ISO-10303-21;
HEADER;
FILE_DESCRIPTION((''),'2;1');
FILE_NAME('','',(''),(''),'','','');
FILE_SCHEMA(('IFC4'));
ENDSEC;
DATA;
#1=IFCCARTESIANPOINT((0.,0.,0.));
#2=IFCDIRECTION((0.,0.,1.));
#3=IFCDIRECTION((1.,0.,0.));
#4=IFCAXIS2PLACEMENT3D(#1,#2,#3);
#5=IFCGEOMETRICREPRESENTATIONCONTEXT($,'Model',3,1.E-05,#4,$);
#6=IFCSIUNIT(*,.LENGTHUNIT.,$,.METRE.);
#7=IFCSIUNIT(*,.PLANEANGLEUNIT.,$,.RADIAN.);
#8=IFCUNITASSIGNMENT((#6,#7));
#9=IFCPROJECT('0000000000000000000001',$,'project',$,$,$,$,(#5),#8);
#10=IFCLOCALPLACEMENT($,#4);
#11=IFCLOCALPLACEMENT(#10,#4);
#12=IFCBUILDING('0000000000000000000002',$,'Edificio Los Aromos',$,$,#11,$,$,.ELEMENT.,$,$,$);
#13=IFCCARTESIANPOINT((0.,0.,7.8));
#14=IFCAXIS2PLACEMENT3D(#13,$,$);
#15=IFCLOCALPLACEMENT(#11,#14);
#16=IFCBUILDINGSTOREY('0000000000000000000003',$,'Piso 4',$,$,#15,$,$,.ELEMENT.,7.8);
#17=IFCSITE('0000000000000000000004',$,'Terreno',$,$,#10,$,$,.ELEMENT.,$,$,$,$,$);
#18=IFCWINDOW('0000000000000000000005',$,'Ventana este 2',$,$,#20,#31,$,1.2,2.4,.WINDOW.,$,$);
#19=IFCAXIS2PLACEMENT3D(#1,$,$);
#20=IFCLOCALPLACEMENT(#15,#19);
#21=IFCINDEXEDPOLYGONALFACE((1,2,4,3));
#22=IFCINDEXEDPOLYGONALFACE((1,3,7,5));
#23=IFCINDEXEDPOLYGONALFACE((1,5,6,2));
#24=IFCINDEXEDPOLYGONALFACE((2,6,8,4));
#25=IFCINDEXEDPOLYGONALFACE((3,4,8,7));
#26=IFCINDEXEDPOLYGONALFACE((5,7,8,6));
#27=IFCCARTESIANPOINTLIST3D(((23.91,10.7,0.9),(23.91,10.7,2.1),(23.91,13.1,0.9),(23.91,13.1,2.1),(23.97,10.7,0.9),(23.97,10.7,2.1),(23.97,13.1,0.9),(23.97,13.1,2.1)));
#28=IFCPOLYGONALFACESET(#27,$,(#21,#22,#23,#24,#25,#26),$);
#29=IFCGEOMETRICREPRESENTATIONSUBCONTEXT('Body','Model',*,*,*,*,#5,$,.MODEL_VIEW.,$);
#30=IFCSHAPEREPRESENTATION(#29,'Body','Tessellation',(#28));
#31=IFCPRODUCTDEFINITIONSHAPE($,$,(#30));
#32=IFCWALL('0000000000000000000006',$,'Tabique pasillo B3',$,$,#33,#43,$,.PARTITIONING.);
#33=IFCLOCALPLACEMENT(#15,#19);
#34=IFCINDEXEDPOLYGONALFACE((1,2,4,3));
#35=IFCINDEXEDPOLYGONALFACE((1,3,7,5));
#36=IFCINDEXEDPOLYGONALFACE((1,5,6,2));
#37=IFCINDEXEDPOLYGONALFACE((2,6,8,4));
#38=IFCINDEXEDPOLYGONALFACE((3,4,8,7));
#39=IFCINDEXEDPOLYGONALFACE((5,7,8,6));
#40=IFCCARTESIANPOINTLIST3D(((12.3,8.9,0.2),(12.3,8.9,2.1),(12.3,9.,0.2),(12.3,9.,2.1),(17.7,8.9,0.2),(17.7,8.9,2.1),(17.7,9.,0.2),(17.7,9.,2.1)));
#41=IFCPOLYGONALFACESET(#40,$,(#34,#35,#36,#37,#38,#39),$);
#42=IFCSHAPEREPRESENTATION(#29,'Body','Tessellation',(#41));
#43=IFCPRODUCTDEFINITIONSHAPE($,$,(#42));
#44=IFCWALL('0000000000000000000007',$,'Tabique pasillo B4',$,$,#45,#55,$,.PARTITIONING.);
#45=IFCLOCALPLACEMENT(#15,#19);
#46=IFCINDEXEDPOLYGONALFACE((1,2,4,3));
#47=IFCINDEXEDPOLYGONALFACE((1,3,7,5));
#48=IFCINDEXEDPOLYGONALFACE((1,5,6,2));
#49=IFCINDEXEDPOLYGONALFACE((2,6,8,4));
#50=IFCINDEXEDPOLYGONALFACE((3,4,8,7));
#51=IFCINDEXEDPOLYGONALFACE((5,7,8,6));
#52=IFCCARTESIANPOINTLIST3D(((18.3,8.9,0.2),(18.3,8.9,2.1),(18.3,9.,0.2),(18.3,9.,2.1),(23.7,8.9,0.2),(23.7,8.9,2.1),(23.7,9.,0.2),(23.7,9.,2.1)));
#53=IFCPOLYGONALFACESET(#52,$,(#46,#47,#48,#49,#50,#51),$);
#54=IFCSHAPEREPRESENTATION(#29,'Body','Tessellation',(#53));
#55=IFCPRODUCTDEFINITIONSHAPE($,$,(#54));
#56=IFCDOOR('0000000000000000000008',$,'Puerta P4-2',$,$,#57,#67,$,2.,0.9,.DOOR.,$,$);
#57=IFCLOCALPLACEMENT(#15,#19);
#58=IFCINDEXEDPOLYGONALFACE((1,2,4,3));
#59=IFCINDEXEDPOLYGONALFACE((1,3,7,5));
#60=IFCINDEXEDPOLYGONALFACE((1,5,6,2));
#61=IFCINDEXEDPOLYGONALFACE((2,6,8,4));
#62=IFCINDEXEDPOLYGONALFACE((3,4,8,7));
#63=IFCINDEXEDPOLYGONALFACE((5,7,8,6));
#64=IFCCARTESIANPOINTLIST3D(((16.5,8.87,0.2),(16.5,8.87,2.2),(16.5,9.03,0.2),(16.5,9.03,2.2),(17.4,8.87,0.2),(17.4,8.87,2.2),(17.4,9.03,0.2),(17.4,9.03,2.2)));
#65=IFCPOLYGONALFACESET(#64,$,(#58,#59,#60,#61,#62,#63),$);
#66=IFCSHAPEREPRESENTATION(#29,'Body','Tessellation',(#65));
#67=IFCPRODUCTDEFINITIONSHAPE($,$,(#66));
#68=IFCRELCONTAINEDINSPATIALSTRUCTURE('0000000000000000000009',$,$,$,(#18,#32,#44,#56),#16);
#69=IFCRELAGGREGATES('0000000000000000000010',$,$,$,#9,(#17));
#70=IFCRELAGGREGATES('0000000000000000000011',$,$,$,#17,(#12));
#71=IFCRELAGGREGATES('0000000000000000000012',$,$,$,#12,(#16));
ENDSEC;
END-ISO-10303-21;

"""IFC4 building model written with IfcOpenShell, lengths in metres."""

from ifc_helpers import new_model, si_unit, frame, frame_2d, origin_with_axes, place, context, subcontext, project, spatial, rectangle, extrude, element, save


model = new_model("IFC4")

# Units and contexts
model_context = context("Model", 3, precision=1e-05, world=origin_with_axes())
body_context = subcontext(model_context, "Body", "Model", "MODEL_VIEW")
ifc_project = project(units=[si_unit("LENGTHUNIT", "METRE"), si_unit("PLANEANGLEUNIT", "RADIAN")], contexts=[model_context])

# Site, building, storey
site_placement = place(None, origin_with_axes())
site = spatial("IfcSite", under=ifc_project, at=site_placement, Name="Terreno", CompositionType="ELEMENT")
building_placement = place(site_placement, origin_with_axes())
building = spatial("IfcBuilding", under=site, at=building_placement, Name="Edificio Los Aromos", CompositionType="ELEMENT")
storey_placement = place(building_placement, frame((0.0, 0.0, 7.8)))
storey = spatial("IfcBuildingStorey", under=building, at=storey_placement, Name="Piso 4", CompositionType="ELEMENT", Elevation=7.8)

# Window
window_1_placement = place(storey_placement, frame((23.91, 10.7, 0.9)))
element("IfcWindow", 1, at=window_1_placement, inside=storey, Name="Ventana este 2", OverallHeight=1.2, OverallWidth=2.4, PredefinedType="WINDOW", context=body_context, shape_type="SweptSolid", body=[
    extrude(rectangle(XDim=0.06, YDim=2.4, at=frame_2d((0.03, 1.2))), origin_with_axes(), (0.0, 0.0, 1.0), 1.2),
])

# Walls
for number, where, name in (
    (2, (12.3, 8.9, 0.2), "Tabique pasillo B3"),
    (3, (18.3, 8.9, 0.2), "Tabique pasillo B4"),
):
    element("IfcWall", number, at=place(storey_placement, frame(where)), inside=storey, Name=name, PredefinedType="PARTITIONING", context=body_context, shape_type="SweptSolid", body=[
        extrude(rectangle(XDim=5.4, YDim=0.1, at=frame_2d((2.7, 0.05))), origin_with_axes(), (0.0, 0.0, 1.0), 1.9),
    ])

# Door
door_placement = place(storey_placement, frame((16.5, 8.87, 0.2)))
element("IfcDoor", 4, at=door_placement, inside=storey, Name="Puerta P4-2", OverallHeight=2.0, OverallWidth=0.9, PredefinedType="DOOR", context=body_context, shape_type="SweptSolid", body=[
    extrude(rectangle(XDim=0.9, YDim=0.16, at=frame_2d((0.45, 0.08))), origin_with_axes(), (0.0, 0.0, 1.0), 2.0),
])

save(model, "model.ifc")
